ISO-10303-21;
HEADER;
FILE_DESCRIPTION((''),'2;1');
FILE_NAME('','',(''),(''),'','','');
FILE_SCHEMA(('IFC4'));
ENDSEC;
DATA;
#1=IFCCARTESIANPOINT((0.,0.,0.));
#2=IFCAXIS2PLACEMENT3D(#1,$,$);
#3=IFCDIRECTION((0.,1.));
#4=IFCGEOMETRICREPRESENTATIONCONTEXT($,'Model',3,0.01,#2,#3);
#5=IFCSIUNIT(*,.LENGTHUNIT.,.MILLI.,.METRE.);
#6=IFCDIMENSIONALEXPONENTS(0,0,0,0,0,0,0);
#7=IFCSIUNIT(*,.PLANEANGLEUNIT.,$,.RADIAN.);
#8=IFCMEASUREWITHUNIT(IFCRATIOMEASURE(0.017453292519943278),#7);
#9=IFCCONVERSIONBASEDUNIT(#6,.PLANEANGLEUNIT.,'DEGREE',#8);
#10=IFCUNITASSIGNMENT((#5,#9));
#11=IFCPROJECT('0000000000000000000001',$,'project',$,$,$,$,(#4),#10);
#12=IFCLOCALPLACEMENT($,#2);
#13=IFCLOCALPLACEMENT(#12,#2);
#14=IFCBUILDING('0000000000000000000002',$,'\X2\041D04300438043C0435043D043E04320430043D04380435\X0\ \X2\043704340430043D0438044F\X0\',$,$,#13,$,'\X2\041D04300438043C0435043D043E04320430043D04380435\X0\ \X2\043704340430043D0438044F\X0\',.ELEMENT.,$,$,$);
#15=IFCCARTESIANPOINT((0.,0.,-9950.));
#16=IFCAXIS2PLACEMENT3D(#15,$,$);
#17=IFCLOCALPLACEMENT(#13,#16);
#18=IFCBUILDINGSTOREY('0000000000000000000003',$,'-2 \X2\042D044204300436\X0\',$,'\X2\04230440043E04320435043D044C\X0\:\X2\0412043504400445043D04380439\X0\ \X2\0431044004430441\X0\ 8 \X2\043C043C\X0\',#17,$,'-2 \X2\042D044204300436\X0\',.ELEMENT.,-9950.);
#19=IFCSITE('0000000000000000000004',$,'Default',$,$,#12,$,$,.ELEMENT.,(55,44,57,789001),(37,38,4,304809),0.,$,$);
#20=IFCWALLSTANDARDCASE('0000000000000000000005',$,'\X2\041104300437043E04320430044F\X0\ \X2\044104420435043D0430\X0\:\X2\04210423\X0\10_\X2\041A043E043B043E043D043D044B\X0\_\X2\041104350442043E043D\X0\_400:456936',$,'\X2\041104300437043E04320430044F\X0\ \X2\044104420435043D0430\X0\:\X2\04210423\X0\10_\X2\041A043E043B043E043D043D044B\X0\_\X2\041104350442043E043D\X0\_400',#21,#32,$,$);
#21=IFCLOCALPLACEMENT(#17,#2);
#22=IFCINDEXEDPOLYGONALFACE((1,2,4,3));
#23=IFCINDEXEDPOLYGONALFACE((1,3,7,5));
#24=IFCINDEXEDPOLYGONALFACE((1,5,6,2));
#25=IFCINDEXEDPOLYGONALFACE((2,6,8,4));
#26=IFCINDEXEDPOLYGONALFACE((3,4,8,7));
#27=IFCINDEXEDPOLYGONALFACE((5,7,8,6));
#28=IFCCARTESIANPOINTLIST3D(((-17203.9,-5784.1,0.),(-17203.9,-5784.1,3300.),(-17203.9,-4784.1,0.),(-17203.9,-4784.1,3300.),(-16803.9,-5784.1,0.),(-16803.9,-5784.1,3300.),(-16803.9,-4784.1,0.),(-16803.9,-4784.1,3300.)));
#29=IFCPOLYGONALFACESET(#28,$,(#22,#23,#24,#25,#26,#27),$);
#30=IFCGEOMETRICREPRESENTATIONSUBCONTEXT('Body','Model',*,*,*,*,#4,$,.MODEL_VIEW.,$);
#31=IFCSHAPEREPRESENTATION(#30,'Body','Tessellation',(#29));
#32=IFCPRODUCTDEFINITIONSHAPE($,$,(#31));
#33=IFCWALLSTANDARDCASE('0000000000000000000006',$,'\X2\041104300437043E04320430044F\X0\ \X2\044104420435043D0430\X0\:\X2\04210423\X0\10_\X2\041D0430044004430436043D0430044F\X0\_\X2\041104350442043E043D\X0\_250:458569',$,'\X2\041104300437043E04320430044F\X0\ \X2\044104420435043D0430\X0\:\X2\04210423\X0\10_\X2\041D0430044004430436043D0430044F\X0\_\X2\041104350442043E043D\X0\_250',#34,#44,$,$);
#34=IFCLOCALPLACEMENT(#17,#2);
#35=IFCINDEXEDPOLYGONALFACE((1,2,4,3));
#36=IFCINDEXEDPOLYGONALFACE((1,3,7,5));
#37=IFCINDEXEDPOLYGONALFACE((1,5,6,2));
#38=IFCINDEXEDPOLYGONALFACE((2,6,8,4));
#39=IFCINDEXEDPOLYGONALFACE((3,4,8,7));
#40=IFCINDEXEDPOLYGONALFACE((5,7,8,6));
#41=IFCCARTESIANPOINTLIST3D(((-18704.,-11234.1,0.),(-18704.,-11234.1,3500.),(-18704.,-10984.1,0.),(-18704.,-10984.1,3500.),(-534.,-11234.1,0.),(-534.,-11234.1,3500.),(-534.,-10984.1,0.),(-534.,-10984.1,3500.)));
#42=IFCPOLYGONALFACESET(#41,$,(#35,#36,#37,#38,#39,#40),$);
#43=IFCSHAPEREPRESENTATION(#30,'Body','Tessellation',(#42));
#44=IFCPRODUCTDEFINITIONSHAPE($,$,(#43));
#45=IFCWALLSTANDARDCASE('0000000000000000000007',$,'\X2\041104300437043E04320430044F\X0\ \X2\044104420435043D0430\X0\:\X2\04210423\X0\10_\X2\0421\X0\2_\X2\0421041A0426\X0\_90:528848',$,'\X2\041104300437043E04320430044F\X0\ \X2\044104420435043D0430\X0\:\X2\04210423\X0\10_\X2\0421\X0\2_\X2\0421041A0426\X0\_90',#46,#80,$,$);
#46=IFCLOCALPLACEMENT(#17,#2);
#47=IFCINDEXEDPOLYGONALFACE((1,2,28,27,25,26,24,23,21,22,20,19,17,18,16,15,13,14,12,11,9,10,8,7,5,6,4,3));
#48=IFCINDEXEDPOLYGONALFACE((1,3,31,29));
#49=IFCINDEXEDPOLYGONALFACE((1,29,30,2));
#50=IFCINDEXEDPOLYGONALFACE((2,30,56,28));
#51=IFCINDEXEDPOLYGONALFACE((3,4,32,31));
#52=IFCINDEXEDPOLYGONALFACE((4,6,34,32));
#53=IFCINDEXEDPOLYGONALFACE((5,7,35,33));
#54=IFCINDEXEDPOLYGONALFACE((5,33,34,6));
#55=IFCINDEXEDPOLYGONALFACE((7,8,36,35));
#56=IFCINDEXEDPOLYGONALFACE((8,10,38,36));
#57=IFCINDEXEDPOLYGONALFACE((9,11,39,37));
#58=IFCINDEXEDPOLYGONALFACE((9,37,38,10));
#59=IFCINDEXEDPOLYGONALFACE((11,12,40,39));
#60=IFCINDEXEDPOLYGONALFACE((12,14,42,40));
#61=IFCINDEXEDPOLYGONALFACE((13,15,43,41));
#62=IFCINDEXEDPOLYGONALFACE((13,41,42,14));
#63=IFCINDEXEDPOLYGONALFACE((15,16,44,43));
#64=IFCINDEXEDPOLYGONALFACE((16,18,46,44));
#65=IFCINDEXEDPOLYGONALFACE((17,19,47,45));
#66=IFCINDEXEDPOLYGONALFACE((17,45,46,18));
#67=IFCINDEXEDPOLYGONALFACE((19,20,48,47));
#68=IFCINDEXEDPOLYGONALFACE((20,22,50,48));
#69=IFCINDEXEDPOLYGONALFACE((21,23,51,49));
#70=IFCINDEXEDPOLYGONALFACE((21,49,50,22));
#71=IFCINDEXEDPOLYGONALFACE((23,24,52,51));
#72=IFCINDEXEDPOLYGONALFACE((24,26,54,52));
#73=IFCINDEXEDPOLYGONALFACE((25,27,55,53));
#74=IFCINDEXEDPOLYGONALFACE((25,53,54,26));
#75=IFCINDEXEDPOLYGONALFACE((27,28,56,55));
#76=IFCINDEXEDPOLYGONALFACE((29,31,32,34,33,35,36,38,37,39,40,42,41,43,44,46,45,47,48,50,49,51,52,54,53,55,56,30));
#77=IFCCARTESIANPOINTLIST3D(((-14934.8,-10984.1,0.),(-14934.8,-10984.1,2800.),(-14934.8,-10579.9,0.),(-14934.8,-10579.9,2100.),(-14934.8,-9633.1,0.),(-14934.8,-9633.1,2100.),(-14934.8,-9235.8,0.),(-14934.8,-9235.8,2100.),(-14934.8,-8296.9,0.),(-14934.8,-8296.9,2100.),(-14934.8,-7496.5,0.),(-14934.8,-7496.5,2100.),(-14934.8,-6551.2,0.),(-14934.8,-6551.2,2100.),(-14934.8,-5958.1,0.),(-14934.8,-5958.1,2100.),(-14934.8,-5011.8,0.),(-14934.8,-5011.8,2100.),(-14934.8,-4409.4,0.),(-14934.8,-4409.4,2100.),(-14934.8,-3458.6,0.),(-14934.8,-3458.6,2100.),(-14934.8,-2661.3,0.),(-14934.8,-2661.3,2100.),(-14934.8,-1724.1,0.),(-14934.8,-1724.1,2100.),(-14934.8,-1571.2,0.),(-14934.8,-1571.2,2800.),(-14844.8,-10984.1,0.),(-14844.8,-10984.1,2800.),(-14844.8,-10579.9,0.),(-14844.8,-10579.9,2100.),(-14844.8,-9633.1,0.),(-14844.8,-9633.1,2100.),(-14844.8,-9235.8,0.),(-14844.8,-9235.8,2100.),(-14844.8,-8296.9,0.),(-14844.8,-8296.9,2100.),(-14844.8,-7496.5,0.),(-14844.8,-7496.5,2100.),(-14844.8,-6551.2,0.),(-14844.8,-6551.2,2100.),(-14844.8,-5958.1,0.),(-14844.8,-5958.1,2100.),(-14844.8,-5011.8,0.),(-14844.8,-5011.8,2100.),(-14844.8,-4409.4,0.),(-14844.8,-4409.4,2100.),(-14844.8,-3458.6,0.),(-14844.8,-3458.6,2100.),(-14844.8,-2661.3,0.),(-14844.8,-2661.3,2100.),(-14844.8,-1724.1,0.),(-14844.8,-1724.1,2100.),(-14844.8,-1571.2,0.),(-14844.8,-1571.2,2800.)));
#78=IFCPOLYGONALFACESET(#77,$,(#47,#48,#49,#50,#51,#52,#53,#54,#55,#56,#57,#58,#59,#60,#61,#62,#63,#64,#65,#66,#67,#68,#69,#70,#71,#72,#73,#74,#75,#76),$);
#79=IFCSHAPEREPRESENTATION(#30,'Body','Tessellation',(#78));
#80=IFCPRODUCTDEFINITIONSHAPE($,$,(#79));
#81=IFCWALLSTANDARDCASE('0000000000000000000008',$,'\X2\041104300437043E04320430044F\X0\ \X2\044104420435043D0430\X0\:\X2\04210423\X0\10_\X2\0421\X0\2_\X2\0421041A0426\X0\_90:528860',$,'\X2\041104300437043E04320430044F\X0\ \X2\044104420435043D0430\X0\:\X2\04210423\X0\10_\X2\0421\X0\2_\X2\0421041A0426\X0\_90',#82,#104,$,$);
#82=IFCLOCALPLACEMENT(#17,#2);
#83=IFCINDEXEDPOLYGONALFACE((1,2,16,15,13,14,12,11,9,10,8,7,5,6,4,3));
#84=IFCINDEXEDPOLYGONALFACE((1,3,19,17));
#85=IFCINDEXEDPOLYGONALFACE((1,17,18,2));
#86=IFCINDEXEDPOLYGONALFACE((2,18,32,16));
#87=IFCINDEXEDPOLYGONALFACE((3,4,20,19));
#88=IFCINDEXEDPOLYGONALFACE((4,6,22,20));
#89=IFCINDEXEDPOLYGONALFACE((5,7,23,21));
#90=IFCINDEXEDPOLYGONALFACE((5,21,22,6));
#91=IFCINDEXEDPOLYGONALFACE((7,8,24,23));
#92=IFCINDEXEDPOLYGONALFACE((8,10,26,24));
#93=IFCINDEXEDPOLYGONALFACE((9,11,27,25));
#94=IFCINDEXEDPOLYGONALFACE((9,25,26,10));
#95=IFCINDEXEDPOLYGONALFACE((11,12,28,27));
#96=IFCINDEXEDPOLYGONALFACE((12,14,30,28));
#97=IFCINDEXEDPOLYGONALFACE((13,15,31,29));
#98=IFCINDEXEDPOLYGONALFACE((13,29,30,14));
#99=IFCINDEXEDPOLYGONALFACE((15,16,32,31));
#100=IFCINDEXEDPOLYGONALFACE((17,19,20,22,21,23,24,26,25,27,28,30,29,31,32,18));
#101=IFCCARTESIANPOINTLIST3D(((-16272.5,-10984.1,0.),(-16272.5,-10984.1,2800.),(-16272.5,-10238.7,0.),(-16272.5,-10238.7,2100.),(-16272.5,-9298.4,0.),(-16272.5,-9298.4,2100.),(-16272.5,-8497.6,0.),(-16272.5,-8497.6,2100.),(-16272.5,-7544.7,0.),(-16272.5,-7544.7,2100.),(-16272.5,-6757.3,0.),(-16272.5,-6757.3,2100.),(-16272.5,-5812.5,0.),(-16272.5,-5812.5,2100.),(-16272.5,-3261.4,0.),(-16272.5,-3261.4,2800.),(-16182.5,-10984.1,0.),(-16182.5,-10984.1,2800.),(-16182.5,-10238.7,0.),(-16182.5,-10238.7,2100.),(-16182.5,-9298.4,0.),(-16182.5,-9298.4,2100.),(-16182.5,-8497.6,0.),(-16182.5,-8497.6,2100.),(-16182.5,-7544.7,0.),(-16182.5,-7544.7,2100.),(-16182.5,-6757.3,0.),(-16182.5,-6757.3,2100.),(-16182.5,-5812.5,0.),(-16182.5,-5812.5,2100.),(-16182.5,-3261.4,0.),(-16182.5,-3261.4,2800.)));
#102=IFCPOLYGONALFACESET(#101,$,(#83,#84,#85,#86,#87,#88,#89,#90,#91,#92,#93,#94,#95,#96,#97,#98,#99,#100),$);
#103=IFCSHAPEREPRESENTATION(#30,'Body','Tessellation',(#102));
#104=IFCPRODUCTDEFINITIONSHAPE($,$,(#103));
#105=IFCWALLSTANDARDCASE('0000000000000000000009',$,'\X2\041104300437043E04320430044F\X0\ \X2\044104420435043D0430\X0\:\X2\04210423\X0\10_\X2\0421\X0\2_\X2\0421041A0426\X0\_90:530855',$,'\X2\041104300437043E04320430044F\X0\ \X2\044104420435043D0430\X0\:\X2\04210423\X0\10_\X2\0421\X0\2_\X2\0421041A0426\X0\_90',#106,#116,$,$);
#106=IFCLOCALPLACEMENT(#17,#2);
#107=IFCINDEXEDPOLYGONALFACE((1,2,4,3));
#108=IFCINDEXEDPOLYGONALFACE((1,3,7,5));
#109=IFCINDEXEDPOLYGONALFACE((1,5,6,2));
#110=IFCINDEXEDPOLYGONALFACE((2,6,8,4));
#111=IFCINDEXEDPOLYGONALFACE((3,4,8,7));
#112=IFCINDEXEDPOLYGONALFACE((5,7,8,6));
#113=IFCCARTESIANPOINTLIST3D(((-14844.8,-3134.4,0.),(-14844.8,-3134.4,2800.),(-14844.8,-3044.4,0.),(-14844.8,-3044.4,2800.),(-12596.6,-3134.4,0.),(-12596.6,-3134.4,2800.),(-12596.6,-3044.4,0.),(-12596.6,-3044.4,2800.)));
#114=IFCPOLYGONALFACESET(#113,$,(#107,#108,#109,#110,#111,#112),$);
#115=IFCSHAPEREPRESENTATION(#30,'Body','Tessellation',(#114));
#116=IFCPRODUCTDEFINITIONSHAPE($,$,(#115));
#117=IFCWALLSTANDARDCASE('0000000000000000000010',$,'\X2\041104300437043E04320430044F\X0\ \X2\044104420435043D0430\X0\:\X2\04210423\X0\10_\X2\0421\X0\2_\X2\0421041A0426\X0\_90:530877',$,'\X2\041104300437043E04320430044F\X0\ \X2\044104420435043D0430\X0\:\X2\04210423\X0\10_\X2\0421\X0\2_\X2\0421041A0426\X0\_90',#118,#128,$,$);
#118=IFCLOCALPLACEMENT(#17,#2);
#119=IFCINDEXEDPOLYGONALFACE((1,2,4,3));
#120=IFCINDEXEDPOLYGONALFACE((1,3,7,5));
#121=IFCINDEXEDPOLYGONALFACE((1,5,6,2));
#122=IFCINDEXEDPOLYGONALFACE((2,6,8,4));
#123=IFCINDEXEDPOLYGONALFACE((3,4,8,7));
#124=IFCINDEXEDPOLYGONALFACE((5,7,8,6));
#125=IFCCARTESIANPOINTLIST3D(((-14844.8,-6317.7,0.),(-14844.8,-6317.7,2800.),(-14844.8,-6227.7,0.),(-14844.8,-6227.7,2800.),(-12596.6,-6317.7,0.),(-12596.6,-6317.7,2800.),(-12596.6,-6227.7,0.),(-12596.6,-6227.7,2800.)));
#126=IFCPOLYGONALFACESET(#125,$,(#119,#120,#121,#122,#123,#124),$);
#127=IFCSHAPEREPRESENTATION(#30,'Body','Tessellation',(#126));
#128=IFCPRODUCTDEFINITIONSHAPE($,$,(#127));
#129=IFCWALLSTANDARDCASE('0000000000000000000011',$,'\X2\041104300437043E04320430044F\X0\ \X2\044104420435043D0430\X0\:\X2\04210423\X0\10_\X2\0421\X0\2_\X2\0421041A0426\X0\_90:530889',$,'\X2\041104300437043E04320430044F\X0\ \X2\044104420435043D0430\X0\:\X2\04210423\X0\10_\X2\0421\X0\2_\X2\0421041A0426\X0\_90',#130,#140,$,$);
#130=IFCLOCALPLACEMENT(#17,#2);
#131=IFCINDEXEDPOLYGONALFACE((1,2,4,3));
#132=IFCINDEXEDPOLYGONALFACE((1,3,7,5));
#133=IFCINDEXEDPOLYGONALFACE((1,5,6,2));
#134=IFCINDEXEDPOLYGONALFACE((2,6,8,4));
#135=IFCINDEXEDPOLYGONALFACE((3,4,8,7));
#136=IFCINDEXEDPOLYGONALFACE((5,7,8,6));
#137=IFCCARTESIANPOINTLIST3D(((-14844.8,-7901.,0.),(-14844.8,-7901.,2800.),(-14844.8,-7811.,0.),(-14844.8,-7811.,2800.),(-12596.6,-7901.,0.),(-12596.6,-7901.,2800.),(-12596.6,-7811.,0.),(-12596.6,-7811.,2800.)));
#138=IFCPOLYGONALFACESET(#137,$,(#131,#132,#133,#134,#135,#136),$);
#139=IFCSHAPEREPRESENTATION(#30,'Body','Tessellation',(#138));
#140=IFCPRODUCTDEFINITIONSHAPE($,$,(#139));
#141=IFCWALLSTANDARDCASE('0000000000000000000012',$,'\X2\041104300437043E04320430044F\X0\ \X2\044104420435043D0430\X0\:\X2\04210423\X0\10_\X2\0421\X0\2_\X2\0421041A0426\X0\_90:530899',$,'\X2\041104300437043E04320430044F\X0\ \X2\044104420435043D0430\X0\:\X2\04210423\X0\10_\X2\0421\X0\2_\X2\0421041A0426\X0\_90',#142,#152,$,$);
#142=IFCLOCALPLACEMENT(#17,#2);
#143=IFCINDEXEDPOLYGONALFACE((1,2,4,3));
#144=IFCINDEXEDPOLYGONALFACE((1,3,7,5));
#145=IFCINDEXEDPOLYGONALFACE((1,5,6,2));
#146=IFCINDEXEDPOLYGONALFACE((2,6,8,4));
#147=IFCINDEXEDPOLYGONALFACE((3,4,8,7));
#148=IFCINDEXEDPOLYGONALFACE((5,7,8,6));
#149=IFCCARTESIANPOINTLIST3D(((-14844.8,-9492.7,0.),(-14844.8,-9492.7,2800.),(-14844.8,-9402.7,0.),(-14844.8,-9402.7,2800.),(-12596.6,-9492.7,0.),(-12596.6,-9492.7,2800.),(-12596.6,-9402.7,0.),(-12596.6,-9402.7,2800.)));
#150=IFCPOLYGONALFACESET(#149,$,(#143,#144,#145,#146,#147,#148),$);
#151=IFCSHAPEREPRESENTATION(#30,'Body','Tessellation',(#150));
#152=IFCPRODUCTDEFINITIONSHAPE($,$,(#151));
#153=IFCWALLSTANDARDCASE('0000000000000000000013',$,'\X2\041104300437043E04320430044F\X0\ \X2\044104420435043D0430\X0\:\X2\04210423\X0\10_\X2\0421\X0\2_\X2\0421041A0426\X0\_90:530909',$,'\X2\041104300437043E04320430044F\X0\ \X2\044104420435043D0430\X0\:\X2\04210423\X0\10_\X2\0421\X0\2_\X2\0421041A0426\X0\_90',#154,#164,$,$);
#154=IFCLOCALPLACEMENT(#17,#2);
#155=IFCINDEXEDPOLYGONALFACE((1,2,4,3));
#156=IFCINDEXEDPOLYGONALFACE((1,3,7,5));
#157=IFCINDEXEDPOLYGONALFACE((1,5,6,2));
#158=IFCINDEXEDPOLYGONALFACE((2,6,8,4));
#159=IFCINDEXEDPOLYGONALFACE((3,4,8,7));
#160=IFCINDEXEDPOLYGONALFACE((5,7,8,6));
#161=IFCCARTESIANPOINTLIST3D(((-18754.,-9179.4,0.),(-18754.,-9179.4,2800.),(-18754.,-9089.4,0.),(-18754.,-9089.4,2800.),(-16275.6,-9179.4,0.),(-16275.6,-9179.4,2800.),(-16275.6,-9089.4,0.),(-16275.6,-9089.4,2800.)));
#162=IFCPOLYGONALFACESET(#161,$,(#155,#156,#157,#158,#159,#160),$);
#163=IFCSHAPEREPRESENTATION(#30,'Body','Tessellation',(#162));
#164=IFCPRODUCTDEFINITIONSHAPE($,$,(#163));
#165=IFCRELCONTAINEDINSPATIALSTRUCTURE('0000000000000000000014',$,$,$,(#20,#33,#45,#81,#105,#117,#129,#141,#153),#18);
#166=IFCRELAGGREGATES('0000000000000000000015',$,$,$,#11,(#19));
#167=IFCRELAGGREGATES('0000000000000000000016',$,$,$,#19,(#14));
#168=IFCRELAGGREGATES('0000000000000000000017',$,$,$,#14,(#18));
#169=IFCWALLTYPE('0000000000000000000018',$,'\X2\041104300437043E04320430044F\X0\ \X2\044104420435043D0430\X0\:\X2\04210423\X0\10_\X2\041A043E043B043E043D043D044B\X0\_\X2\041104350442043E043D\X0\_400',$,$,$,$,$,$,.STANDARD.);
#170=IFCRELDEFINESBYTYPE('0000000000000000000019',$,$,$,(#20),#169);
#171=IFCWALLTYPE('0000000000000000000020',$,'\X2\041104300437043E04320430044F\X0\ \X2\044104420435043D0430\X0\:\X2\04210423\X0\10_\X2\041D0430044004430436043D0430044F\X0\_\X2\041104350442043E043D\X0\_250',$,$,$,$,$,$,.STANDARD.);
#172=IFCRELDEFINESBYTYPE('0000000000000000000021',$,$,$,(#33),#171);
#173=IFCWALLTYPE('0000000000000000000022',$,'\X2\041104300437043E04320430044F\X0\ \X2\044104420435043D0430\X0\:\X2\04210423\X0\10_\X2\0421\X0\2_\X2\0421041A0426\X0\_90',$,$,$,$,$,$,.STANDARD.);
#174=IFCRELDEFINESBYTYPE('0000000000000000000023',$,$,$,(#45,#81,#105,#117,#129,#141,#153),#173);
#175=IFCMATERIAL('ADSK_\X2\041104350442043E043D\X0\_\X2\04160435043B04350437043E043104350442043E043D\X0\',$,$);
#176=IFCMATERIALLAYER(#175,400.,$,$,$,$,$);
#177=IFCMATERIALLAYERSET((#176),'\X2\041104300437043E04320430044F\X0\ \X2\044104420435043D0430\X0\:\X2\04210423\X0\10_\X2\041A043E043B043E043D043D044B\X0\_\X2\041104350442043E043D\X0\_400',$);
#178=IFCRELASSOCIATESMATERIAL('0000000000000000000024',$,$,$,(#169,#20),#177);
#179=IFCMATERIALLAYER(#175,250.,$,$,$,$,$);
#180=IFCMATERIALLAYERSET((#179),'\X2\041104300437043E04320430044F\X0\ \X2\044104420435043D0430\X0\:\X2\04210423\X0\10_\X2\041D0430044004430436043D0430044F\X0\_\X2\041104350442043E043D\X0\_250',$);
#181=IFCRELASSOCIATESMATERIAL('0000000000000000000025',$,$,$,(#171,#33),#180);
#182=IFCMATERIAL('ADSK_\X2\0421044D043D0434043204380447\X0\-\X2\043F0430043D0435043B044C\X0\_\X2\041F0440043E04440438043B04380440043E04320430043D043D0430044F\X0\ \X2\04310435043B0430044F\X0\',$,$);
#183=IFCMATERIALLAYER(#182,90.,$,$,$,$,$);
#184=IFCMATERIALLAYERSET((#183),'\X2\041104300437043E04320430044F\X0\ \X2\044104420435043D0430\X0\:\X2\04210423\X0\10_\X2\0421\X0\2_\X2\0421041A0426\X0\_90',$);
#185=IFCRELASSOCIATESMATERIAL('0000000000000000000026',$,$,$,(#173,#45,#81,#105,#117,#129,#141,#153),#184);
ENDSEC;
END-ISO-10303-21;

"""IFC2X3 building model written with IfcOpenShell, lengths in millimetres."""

from ifc_helpers import new_model, entity, si_unit, converted_unit, direction, frame, frame_2d, origin, place, context, subcontext, project, spatial, rectangle, extrude, material, layer, layer_set, layer_usage, type_object, element, save


model = new_model("IFC2X3")

# Units and contexts
model_context = context("Model", 3, precision=0.01, world=origin(), true_north=direction((0.0, 1.0)))
body_context = subcontext(model_context, "Body", "Model", "MODEL_VIEW")
ifc_project = project(units=[si_unit("LENGTHUNIT", "METRE", prefix="MILLI"), converted_unit("PLANEANGLEUNIT", "DEGREE", entity("IfcRatioMeasure", 0.017453292519943278), si_unit("PLANEANGLEUNIT", "RADIAN"), dimensions=[0, 0, 0, 0, 0, 0, 0])], contexts=[model_context])

# Site, building, storey
site_placement = place(None, origin())
site = spatial("IfcSite", under=ifc_project, at=site_placement, Name="Default", CompositionType="ELEMENT", RefLatitude=(55, 44, 57, 789001), RefLongitude=(37, 38, 4, 304809), RefElevation=0.0)
building_placement = place(site_placement, origin())
building = spatial("IfcBuilding", under=site, at=building_placement, Name="Наименование здания", LongName="Наименование здания", CompositionType="ELEMENT")
storey_placement = place(building_placement, frame((0.0, 0.0, -9950.0)))
storey = spatial("IfcBuildingStorey", under=building, at=storey_placement, Name="-2 Этаж", ObjectType="Уровень:Верхний брус 8 мм", LongName="-2 Этаж", CompositionType="ELEMENT", Elevation=-9950.0)

# Walls
ifc_material_1 = material(Name="ADSK_Бетон_Железобетон")
ifc_layer_1 = layer(ifc_material_1, 400.0)
ifc_layer_set_1 = layer_set([ifc_layer_1], Name="Базовая стена:СУ10_Колонны_Бетон_400")
ifc_layer_usage_1 = layer_usage(ifc_layer_set_1, "AXIS2", "NEGATIVE", 200.0)
wall_type_1 = type_object("IfcWallType", Name="Базовая стена:СУ10_Колонны_Бетон_400", PredefinedType="STANDARD", material=ifc_layer_set_1)
wall_1_placement = place(storey_placement, frame((-17003.9, -5784.1, 0.0), z_axis=(0.0, 0.0, 1.0), x_axis=(0.0, 1.0, 0.0)))
element("IfcWallStandardCase", 1, at=wall_1_placement, inside=storey, type_object=wall_type_1, material=ifc_layer_usage_1, Name="Базовая стена:СУ10_Колонны_Бетон_400:456936", ObjectType="Базовая стена:СУ10_Колонны_Бетон_400", context=body_context, shape_type="SweptSolid", body=[
    extrude(rectangle(XDim=1000.0, YDim=400.0, at=frame_2d((500.0, 0.0), x_axis=(-1.0, 0.0))), origin(), (0.0, 0.0, 1.0), 3300.0),
])
ifc_layer_2 = layer(ifc_material_1, 250.0)
ifc_layer_set_2 = layer_set([ifc_layer_2], Name="Базовая стена:СУ10_Наружная_Бетон_250")
ifc_layer_usage_2 = layer_usage(ifc_layer_set_2, "AXIS2", "NEGATIVE", 125.0)
wall_type_2 = type_object("IfcWallType", Name="Базовая стена:СУ10_Наружная_Бетон_250", PredefinedType="STANDARD", material=ifc_layer_set_2)
wall_2_placement = place(storey_placement, frame((-18704.0, -11109.1, 0.0)))
element("IfcWallStandardCase", 2, at=wall_2_placement, inside=storey, type_object=wall_type_2, material=ifc_layer_usage_2, Name="Базовая стена:СУ10_Наружная_Бетон_250:458569", ObjectType="Базовая стена:СУ10_Наружная_Бетон_250", context=body_context, shape_type="SweptSolid", body=[
    extrude(rectangle(XDim=18170.1, YDim=250.0, at=frame_2d((9085.0, 0.0), x_axis=(-1.0, 0.0))), origin(), (0.0, 0.0, 1.0), 3500.0),
])

# Walls, openings
ifc_material_2 = material(Name="ADSK_Сэндвич-панель_Профилированная белая")
ifc_layer_3 = layer(ifc_material_2, 90.0)
ifc_layer_set_3 = layer_set([ifc_layer_3], Name="Базовая стена:СУ10_С2_СКЦ_90")
ifc_layer_usage_3 = layer_usage(ifc_layer_set_3, "AXIS2", "NEGATIVE", 45.0)
wall_type_3 = type_object("IfcWallType", Name="Базовая стена:СУ10_С2_СКЦ_90", PredefinedType="STANDARD", material=ifc_layer_set_3)
wall_3_placement = place(storey_placement, frame((-14889.8, -1571.2, 0.0), z_axis=(0.0, 0.0, 1.0), x_axis=(0.0, -1.0, 0.0)))
wall_3 = element("IfcWallStandardCase", 3, at=wall_3_placement, inside=storey, type_object=wall_type_3, material=ifc_layer_usage_3, Name="Базовая стена:СУ10_С2_СКЦ_90:528848", ObjectType="Базовая стена:СУ10_С2_СКЦ_90", context=body_context, shape_type="SweptSolid", body=[
    extrude(rectangle(XDim=9412.9, YDim=90.0, at=frame_2d((4706.4, 0.0), x_axis=(-1.0, 0.0))), origin(), (0.0, 0.0, 1.0), 2800.0),
])
opening_1_placement = place(wall_3_placement, origin())
element("IfcOpeningElement", 4, at=opening_1_placement, cuts=wall_3, ObjectType="Opening", context=body_context, shape_type="SweptSolid", body=[
    extrude(rectangle(XDim=2100.0, YDim=937.2, at=frame_2d((0.0, 0.0), x_axis=(1.0, 0.0))), frame((621.5, -45.0, 1050.0), z_axis=(0.0, 1.0, 0.0), x_axis=(0.0, 0.0, -1.0)), (0.0, 0.0, 1.0), 90.0),
])
opening_2_placement = place(wall_3_placement, origin())
element("IfcOpeningElement", 5, at=opening_2_placement, cuts=wall_3, ObjectType="Opening", context=body_context, shape_type="SweptSolid", body=[
    extrude(rectangle(XDim=2100.0, YDim=950.7, at=frame_2d((0.0, 0.0), x_axis=(1.0, 0.0))), frame((2362.8, -45.0, 1050.0), z_axis=(0.0, 1.0, 0.0), x_axis=(0.0, 0.0, -1.0)), (0.0, 0.0, 1.0), 90.0),
])
opening_3_placement = place(wall_3_placement, origin())
element("IfcOpeningElement", 6, at=opening_3_placement, cuts=wall_3, ObjectType="Opening", context=body_context, shape_type="SweptSolid", body=[
    extrude(rectangle(XDim=2100.0, YDim=946.3, at=frame_2d((0.0, 0.0), x_axis=(1.0, 0.0))), frame((3913.8, -45.0, 1050.0), z_axis=(0.0, 1.0, 0.0), x_axis=(0.0, 0.0, -1.0)), (0.0, 0.0, 1.0), 90.0),
])
opening_4_placement = place(wall_3_placement, origin())
element("IfcOpeningElement", 7, at=opening_4_placement, cuts=wall_3, ObjectType="Opening", context=body_context, shape_type="SweptSolid", body=[
    extrude(rectangle(XDim=2100.0, YDim=945.4, at=frame_2d((0.0, 0.0), x_axis=(1.0, 0.0))), frame((5452.6, -45.0, 1050.0), z_axis=(0.0, 1.0, 0.0), x_axis=(0.0, 0.0, -1.0)), (0.0, 0.0, 1.0), 90.0),
])
opening_5_placement = place(wall_3_placement, origin())
element("IfcOpeningElement", 8, at=opening_5_placement, cuts=wall_3, ObjectType="Opening", context=body_context, shape_type="SweptSolid", body=[
    extrude(rectangle(XDim=2100.0, YDim=938.9, at=frame_2d((0.0, 0.0), x_axis=(1.0, 0.0))), frame((7195.1, -45.0, 1050.0), z_axis=(0.0, 1.0, 0.0), x_axis=(0.0, 0.0, -1.0)), (0.0, 0.0, 1.0), 90.0),
])
opening_6_placement = place(wall_3_placement, origin())
element("IfcOpeningElement", 9, at=opening_6_placement, cuts=wall_3, ObjectType="Opening", context=body_context, shape_type="SweptSolid", body=[
    extrude(rectangle(XDim=2100.0, YDim=946.8, at=frame_2d((0.0, 0.0), x_axis=(1.0, 0.0))), frame((8535.3, -45.0, 1050.0), z_axis=(0.0, 1.0, 0.0), x_axis=(0.0, 0.0, -1.0)), (0.0, 0.0, 1.0), 90.0),
])
wall_4_placement = place(storey_placement, frame((-16227.5, -3261.4, 0.0), z_axis=(0.0, 0.0, 1.0), x_axis=(0.0, -1.0, 0.0)))
wall_4 = element("IfcWallStandardCase", 10, at=wall_4_placement, inside=storey, type_object=wall_type_3, material=ifc_layer_usage_3, Name="Базовая стена:СУ10_С2_СКЦ_90:528860", ObjectType="Базовая стена:СУ10_С2_СКЦ_90", context=body_context, shape_type="SweptSolid", body=[
    extrude(rectangle(XDim=7722.7, YDim=90.0, at=frame_2d((3861.4, 0.0), x_axis=(-1.0, 0.0))), origin(), (0.0, 0.0, 1.0), 2800.0),
])
opening_7_placement = place(wall_4_placement, origin())
element("IfcOpeningElement", 11, at=opening_7_placement, cuts=wall_4, ObjectType="Opening", context=body_context, shape_type="SweptSolid", body=[
    extrude(rectangle(XDim=2100.0, YDim=940.4, at=frame_2d((0.0, 0.0), x_axis=(1.0, 0.0))), frame((6507.2, -45.0, 1050.0), z_axis=(0.0, 1.0, 0.0), x_axis=(0.0, 0.0, -1.0)), (0.0, 0.0, 1.0), 90.0),
])
opening_8_placement = place(wall_4_placement, origin())
element("IfcOpeningElement", 12, at=opening_8_placement, cuts=wall_4, ObjectType="Opening", context=body_context, shape_type="SweptSolid", body=[
    extrude(rectangle(XDim=2100.0, YDim=953.0, at=frame_2d((0.0, 0.0), x_axis=(1.0, 0.0))), frame((4759.8, -45.0, 1050.0), z_axis=(0.0, 1.0, 0.0), x_axis=(0.0, 0.0, -1.0)), (0.0, 0.0, 1.0), 90.0),
])
opening_9_placement = place(wall_4_placement, origin())
element("IfcOpeningElement", 13, at=opening_9_placement, cuts=wall_4, ObjectType="Opening", context=body_context, shape_type="SweptSolid", body=[
    extrude(rectangle(XDim=2100.0, YDim=944.8, at=frame_2d((0.0, 0.0), x_axis=(1.0, 0.0))), frame((3023.5, -45.0, 1050.0), z_axis=(0.0, 1.0, 0.0), x_axis=(0.0, 0.0, -1.0)), (0.0, 0.0, 1.0), 90.0),
])

# Walls
wall_5_placement = place(storey_placement, frame((-12596.6, -3089.4, 0.0), z_axis=(0.0, 0.0, 1.0), x_axis=(-1.0, 0.0, 0.0)))
element("IfcWallStandardCase", 14, at=wall_5_placement, inside=storey, type_object=wall_type_3, material=ifc_layer_usage_3, Name="Базовая стена:СУ10_С2_СКЦ_90:530855", ObjectType="Базовая стена:СУ10_С2_СКЦ_90", context=body_context, shape_type="SweptSolid", body=[
    extrude(rectangle(XDim=2248.2, YDim=90.0, at=frame_2d((1124.1, 0.0), x_axis=(-1.0, 0.0))), origin(), (0.0, 0.0, 1.0), 2800.0),
])
for number, where, z_axis, x_axis, name in (
    (15, (-12596.6, -6272.7, 0.0), (0.0, 0.0, 1.0), (-1.0, 0.0, 0.0), "Базовая стена:СУ10_С2_СКЦ_90:530877"),
    (16, (-12596.6, -7856.0, 0.0), (0.0, 0.0, 1.0), (-1.0, 0.0, 0.0), "Базовая стена:СУ10_С2_СКЦ_90:530889"),
    (17, (-12596.6, -9447.7, 0.0), (0.0, 0.0, 1.0), (-1.0, 0.0, 0.0), "Базовая стена:СУ10_С2_СКЦ_90:530899"),
):
    element("IfcWallStandardCase", number, at=place(storey_placement, frame(where, z_axis=z_axis, x_axis=x_axis)), inside=storey, type_object=wall_type_3, material=ifc_layer_usage_3, Name=name, ObjectType="Базовая стена:СУ10_С2_СКЦ_90", context=body_context, shape_type="SweptSolid", body=[
        extrude(rectangle(XDim=2248.2, YDim=90.0, at=frame_2d((1124.1, 0.0), x_axis=(-1.0, 0.0))), origin(), (0.0, 0.0, 1.0), 2800.0),
    ])
wall_6_placement = place(storey_placement, frame((-16275.6, -9134.4, 0.0), z_axis=(0.0, 0.0, 1.0), x_axis=(-1.0, 0.0, 0.0)))
element("IfcWallStandardCase", 18, at=wall_6_placement, inside=storey, type_object=wall_type_3, material=ifc_layer_usage_3, Name="Базовая стена:СУ10_С2_СКЦ_90:530909", ObjectType="Базовая стена:СУ10_С2_СКЦ_90", context=body_context, shape_type="SweptSolid", body=[
    extrude(rectangle(XDim=2478.4, YDim=90.0, at=frame_2d((1239.2, 0.0), x_axis=(-1.0, 0.0))), origin(), (0.0, 0.0, 1.0), 2800.0),
])

save(model, "model.ifc")
